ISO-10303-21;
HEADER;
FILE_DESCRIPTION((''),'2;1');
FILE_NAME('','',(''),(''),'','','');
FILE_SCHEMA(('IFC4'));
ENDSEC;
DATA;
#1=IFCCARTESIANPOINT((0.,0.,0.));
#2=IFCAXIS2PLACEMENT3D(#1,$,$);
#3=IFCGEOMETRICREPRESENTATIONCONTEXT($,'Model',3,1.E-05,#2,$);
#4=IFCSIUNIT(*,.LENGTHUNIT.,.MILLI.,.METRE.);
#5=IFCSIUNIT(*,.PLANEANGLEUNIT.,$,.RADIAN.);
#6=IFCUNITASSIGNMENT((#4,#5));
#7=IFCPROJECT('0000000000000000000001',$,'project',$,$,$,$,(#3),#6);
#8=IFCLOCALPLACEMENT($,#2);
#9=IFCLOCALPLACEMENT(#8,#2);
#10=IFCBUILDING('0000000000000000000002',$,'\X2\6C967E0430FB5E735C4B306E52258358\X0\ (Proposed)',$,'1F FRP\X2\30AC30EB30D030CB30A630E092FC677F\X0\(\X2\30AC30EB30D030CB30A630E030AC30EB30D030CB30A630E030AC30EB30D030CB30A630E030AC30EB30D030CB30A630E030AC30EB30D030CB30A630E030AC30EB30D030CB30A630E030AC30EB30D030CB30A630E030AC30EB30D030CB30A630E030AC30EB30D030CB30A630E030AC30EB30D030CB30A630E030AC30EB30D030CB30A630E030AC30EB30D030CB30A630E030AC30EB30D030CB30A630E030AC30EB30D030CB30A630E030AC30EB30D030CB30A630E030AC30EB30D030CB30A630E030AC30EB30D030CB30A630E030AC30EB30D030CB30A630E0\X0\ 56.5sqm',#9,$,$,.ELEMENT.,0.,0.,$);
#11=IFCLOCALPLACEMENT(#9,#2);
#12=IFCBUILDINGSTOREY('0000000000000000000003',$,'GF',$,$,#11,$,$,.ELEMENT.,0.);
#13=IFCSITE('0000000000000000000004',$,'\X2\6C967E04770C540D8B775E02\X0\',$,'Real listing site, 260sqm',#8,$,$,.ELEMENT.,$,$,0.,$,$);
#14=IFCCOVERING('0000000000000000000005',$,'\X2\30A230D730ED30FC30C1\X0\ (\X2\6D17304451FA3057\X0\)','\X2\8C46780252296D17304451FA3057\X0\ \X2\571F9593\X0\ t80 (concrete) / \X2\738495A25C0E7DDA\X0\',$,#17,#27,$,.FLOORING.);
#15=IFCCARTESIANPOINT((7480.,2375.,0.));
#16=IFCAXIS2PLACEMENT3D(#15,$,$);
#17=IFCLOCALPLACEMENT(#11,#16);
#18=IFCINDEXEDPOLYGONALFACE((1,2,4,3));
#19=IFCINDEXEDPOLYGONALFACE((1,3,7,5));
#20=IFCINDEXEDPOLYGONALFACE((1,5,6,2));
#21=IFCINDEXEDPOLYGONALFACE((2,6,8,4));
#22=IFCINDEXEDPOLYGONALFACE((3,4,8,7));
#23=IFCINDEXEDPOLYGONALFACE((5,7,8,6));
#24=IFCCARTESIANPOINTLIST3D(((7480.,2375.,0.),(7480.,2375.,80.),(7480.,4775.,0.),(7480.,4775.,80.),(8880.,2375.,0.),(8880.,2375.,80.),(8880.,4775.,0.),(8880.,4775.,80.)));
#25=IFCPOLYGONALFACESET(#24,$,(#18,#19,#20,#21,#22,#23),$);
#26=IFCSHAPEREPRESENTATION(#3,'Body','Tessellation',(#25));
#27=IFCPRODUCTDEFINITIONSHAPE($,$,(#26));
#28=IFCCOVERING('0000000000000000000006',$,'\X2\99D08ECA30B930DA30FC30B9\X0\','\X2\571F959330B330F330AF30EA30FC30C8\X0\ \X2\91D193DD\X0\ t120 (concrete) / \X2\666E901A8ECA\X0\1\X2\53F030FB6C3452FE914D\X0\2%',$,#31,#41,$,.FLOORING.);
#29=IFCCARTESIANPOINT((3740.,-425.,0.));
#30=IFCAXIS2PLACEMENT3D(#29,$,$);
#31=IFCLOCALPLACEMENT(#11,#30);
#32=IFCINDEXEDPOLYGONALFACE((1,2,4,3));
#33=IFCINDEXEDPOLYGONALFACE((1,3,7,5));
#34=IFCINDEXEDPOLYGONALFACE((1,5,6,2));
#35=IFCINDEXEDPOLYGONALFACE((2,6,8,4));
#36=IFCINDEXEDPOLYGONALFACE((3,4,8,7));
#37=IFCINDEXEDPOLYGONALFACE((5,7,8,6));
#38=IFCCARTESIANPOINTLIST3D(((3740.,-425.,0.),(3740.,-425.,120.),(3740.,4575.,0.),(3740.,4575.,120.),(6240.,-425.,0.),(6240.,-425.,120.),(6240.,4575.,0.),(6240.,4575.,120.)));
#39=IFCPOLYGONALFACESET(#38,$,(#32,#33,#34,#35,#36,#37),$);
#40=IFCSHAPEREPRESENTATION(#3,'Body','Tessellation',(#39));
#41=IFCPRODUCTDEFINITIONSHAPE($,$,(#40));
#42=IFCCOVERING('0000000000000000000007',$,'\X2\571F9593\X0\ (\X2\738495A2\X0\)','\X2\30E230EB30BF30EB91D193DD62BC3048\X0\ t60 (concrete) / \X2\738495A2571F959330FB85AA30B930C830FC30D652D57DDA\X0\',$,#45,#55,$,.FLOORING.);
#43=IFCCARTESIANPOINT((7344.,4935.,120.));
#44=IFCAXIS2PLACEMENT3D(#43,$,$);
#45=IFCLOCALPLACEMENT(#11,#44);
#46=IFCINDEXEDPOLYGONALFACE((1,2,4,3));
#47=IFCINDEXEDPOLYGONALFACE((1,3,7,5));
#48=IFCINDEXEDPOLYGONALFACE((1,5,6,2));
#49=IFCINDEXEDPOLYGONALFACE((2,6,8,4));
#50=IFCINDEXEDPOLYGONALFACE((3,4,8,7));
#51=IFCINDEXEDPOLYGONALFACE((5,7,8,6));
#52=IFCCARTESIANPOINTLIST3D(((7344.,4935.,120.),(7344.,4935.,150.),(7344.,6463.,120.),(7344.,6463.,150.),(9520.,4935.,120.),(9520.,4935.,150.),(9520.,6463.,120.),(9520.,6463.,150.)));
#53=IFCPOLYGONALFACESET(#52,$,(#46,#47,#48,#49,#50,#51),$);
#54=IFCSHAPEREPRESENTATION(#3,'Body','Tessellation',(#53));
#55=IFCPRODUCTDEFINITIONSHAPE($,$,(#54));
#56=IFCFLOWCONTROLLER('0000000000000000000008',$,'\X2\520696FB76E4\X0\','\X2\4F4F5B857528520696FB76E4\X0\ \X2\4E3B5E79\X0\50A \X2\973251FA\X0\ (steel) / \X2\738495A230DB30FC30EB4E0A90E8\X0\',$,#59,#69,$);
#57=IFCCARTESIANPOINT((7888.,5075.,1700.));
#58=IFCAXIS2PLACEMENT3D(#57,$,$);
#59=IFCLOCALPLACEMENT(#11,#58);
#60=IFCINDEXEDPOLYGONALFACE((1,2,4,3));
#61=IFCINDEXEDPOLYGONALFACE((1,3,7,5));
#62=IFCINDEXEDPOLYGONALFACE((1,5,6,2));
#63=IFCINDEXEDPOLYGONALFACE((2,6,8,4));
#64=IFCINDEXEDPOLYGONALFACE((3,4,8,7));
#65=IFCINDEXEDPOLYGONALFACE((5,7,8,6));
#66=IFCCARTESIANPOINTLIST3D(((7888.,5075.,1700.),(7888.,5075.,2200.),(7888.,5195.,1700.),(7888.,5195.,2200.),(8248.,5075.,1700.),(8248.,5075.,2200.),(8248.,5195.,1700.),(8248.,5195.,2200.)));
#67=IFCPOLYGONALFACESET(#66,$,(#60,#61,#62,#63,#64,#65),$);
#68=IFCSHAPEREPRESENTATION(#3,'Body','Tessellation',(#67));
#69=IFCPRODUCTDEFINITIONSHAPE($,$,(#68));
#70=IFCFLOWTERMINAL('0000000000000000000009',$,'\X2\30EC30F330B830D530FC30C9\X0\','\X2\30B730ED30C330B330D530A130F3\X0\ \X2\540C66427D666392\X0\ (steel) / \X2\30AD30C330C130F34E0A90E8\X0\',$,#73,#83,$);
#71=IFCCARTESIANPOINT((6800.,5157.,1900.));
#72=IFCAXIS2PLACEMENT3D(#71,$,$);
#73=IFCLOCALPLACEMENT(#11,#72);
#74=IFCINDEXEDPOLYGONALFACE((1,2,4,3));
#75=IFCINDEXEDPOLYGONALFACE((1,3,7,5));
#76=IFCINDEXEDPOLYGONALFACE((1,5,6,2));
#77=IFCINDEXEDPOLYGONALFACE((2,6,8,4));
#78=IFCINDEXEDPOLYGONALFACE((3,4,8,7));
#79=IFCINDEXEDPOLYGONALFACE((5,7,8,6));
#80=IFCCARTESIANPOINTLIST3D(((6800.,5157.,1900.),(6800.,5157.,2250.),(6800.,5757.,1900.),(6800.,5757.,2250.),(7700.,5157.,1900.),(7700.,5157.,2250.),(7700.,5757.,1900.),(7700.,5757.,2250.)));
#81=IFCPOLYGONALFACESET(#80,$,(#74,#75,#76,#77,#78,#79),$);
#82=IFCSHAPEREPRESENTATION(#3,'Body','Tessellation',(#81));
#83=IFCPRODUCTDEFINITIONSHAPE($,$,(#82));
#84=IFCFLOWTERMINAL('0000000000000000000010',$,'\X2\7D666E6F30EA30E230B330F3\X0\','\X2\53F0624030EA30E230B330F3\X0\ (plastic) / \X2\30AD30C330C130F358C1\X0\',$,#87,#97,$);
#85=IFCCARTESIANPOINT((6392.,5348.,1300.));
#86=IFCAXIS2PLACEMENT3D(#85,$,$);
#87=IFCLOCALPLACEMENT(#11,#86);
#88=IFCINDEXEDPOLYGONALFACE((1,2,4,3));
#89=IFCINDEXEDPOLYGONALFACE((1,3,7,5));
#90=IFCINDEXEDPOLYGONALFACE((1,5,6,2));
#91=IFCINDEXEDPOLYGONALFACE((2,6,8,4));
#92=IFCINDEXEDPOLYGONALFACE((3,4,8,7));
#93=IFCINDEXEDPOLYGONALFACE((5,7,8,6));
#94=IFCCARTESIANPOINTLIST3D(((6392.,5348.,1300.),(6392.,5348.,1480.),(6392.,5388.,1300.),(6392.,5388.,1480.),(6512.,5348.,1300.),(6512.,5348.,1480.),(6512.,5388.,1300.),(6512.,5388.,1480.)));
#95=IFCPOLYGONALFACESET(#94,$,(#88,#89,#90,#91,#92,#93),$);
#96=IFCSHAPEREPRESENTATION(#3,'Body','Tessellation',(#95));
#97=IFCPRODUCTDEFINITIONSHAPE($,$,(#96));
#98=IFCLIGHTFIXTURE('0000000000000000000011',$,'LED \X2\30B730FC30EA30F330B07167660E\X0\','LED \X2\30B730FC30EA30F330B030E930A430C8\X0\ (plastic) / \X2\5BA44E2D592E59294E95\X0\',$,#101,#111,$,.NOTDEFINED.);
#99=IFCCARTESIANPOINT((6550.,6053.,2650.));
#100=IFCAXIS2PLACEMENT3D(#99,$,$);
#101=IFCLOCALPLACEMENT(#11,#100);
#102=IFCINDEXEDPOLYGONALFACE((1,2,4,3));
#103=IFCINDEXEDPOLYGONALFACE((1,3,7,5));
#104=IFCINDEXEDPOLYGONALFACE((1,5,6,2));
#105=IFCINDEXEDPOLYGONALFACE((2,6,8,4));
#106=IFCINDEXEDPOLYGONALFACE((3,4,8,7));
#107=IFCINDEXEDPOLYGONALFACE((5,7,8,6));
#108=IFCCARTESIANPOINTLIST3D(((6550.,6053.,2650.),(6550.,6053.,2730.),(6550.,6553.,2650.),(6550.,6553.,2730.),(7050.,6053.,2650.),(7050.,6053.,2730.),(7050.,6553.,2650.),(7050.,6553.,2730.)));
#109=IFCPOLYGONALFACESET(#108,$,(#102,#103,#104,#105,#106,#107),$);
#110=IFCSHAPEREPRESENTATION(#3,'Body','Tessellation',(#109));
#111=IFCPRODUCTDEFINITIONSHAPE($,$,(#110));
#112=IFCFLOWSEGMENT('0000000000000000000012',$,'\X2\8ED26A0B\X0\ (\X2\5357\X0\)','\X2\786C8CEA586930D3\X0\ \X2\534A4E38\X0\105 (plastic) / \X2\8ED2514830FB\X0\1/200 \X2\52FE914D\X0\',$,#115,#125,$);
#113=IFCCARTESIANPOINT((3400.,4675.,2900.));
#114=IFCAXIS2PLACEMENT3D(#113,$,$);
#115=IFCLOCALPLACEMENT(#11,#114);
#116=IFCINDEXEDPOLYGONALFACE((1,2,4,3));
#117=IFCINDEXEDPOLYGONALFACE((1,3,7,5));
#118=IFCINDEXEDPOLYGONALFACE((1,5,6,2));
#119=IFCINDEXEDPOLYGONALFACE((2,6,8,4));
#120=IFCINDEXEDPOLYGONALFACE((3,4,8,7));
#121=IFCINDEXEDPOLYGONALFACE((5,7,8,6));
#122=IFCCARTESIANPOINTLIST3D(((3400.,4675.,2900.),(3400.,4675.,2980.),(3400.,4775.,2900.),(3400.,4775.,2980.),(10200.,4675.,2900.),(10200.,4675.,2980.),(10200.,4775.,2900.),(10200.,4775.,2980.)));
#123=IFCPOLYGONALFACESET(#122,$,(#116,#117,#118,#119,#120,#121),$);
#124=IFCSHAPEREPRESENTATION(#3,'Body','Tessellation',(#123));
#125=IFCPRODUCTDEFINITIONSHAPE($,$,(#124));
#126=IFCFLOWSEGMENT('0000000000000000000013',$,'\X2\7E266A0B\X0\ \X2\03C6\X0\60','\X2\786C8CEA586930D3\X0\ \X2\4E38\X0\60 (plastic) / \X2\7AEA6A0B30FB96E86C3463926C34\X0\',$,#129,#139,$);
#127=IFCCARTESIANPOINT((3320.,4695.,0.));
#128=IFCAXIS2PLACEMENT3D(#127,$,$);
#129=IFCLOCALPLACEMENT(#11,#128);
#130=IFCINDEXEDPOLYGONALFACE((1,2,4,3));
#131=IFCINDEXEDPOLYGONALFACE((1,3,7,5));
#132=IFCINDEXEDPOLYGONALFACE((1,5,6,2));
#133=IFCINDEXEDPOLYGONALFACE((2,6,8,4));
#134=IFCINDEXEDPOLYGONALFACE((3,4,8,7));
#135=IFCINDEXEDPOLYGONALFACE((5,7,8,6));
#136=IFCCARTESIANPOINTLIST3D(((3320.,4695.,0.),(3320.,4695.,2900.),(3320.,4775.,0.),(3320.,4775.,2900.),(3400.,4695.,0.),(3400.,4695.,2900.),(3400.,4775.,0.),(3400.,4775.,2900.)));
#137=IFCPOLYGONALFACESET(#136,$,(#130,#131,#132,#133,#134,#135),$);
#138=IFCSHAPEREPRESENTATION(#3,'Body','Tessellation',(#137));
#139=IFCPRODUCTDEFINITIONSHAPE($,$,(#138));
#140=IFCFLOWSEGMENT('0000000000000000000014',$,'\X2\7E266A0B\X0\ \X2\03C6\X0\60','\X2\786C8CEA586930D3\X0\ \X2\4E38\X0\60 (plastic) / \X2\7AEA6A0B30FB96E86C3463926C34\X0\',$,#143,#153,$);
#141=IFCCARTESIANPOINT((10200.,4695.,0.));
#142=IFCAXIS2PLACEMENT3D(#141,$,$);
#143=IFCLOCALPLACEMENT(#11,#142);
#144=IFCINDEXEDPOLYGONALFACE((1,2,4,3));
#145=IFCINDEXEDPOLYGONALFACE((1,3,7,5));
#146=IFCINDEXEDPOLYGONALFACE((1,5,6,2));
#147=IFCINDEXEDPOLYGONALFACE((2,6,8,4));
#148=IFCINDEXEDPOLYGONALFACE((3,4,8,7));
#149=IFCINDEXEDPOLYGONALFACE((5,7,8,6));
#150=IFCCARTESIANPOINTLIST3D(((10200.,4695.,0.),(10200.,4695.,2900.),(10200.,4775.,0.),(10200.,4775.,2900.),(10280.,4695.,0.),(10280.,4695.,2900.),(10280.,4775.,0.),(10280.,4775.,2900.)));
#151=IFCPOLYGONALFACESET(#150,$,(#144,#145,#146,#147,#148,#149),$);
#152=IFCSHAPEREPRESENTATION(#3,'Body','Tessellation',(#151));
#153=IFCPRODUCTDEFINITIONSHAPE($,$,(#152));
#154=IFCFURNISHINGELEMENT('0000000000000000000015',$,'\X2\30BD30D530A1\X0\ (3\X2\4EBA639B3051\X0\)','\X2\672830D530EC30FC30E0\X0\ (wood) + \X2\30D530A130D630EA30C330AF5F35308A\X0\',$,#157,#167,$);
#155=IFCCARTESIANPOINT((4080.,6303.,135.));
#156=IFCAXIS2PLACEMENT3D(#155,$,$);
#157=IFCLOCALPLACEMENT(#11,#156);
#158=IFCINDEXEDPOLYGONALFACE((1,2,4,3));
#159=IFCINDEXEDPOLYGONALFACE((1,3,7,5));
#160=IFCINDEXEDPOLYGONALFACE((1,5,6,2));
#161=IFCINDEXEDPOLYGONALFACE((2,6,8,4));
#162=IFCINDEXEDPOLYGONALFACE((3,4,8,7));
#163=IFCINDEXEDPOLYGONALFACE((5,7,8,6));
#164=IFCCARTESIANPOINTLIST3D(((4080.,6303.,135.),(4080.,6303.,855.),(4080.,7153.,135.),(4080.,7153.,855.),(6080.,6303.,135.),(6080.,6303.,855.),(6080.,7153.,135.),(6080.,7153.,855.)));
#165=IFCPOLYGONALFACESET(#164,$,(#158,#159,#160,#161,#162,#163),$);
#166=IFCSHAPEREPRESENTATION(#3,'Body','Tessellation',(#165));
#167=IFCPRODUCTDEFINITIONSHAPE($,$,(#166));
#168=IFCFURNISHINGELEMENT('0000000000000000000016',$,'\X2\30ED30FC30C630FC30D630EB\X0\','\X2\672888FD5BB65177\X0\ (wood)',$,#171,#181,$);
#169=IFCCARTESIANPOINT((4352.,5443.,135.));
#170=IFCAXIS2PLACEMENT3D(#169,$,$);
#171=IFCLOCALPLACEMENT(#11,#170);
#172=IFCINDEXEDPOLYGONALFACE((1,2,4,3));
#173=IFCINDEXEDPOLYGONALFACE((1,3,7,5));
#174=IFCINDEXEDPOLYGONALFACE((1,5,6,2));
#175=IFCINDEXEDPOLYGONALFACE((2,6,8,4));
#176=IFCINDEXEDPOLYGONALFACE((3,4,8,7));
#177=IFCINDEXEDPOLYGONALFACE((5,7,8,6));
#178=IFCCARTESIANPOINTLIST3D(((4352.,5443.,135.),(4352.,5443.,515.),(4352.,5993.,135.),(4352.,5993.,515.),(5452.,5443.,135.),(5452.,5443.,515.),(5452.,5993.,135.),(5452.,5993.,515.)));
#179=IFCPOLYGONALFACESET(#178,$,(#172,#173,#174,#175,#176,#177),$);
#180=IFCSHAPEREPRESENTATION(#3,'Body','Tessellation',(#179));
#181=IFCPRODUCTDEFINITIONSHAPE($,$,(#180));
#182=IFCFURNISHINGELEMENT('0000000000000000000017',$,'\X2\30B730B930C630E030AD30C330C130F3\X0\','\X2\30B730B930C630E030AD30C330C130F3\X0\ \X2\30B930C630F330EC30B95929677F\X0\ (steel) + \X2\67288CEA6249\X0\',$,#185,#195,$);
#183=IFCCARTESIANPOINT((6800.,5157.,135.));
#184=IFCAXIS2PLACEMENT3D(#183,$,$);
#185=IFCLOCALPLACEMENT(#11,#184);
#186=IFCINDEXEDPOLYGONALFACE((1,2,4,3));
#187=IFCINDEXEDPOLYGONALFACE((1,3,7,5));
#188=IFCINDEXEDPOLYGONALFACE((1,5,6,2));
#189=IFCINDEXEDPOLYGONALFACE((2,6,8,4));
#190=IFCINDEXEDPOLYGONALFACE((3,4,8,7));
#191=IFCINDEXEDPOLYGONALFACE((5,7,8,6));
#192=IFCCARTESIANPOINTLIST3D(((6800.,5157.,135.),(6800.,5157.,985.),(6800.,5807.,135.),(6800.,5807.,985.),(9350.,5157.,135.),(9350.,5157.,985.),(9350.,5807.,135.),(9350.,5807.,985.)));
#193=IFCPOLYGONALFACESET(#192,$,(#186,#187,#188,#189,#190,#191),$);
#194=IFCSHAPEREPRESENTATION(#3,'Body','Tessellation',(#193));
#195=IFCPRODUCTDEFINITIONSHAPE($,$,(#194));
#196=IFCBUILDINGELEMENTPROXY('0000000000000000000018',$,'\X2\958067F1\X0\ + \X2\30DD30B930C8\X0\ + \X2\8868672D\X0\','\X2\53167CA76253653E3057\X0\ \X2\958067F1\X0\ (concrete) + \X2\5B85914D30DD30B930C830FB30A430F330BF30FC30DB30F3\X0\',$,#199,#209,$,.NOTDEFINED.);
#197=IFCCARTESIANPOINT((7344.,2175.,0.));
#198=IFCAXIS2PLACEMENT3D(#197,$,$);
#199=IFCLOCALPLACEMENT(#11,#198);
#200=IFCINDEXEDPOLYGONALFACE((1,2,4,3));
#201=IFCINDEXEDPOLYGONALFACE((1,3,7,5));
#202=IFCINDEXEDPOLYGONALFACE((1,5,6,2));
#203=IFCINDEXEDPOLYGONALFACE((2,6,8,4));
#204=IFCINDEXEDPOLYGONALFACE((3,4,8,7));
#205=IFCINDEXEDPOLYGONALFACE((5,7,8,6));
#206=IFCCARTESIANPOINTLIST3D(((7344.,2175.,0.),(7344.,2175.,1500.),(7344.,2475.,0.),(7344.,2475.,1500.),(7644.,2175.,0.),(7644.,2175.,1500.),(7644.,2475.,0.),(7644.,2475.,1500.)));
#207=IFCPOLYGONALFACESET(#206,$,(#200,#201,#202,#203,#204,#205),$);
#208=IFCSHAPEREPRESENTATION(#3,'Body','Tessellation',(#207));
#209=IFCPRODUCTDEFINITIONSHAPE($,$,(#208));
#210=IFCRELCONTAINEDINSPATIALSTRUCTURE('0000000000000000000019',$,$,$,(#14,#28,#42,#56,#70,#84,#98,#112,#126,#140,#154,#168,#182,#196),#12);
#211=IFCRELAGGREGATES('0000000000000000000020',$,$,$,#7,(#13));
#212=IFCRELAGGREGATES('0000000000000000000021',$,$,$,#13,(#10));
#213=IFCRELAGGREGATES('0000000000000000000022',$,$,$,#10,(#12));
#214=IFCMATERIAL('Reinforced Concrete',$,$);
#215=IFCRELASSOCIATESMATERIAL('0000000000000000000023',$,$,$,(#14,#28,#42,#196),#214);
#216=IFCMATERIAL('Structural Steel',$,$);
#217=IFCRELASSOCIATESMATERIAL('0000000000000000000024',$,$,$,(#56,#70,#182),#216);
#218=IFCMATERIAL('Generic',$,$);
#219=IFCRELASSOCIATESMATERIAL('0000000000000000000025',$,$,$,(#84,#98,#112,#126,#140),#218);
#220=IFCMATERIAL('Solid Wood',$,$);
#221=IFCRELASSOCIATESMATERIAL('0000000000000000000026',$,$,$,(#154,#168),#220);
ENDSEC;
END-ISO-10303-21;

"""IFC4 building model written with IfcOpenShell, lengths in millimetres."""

from ifc_helpers import new_model, si_unit, frame, frame_2d, origin, place, context, project, spatial, rectangle, extrude, material, element, save


model = new_model("IFC4")

# Units and contexts
model_context = context("Model", 3, precision=1e-05, world=origin())
ifc_project = project(units=[si_unit("LENGTHUNIT", "METRE", prefix="MILLI"), si_unit("PLANEANGLEUNIT", "RADIAN")], contexts=[model_context])

# Site, building, storey
site_placement = place(None, origin())
site = spatial("IfcSite", under=ifc_project, at=site_placement, Name="沖縄県名護市", ObjectType="Real listing site, 260sqm", CompositionType="ELEMENT", RefElevation=0.0)
building_placement = place(site_placement, origin())
building = spatial("IfcBuilding", under=site, at=building_placement, Name="沖縄・平屋の別荘 (Proposed)", ObjectType="1F FRPガルバニウム鋼板(ガルバニウムガルバニウムガルバニウムガルバニウムガルバニウムガルバニウムガルバニウムガルバニウムガルバニウムガルバニウムガルバニウムガルバニウムガルバニウムガルバニウムガルバニウムガルバニウムガルバニウムガルバニウム 56.5sqm", CompositionType="ELEMENT", ElevationOfRefHeight=0.0, ElevationOfTerrain=0.0)
storey_placement = place(building_placement, origin())
storey = spatial("IfcBuildingStorey", under=building, at=storey_placement, Name="GF", CompositionType="ELEMENT", Elevation=0.0)

# Shared definitions
ifc_material_1 = material(Name="Solid Wood")

# Shared definitions
ifc_material_2 = material(Name="Reinforced Concrete")

# Shared definitions
ifc_material_3 = material(Name="Structural Steel")

# Coverings
ifc_material_4 = material(Name="Generic")
covering_1_placement = place(storey_placement, frame((7480.0, 2375.0, 0.0)))
element("IfcCovering", 1, at=covering_1_placement, inside=storey, material=ifc_material_2, Name="アプローチ (洗い出し)", Description="豆砂利洗い出し 土間 t80 (concrete) / 玄関導線", PredefinedType="FLOORING", context=model_context, shape_type="SweptSolid", body=[
    extrude(rectangle(XDim=1400.0, YDim=2400.0, at=frame_2d((700.0, 1200.0))), frame((7480.0, 2375.0, 0.0)), (0.0, 0.0, 1.0), 80.0),
])
covering_2_placement = place(storey_placement, frame((3740.0, -425.0, 0.0)))
element("IfcCovering", 2, at=covering_2_placement, inside=storey, material=ifc_material_2, Name="駐車スペース", Description="土間コンクリート 金鏝 t120 (concrete) / 普通車1台・水勾配2%", PredefinedType="FLOORING", context=model_context, shape_type="SweptSolid", body=[
    extrude(rectangle(XDim=2500.0, YDim=5000.0, at=frame_2d((1250.0, 2500.0))), frame((3740.0, -425.0, 0.0)), (0.0, 0.0, 1.0), 120.0),
])
covering_3_placement = place(storey_placement, frame((7344.0, 4935.0, 120.0)))
element("IfcCovering", 3, at=covering_3_placement, inside=storey, material=ifc_material_2, Name="土間 (玄関)", Description="モルタル金鏝押え t60 (concrete) / 玄関土間・薪ストーブ動線", PredefinedType="FLOORING", context=model_context, shape_type="SweptSolid", body=[
    extrude(rectangle(XDim=2176.0, YDim=1528.0, at=frame_2d((1088.0, 764.0))), frame((7344.0, 4935.0, 120.0)), (0.0, 0.0, 1.0), 30.0),
])

# Flow controller
flow_controller_placement = place(storey_placement, frame((7888.0, 5075.0, 1700.0)))
element("IfcFlowController", 4, at=flow_controller_placement, inside=storey, material=ifc_material_3, Name="分電盤", Description="住宅用分電盤 主幹50A 露出 (steel) / 玄関ホール上部", context=model_context, shape_type="SweptSolid", body=[
    extrude(rectangle(XDim=360.0, YDim=120.0, at=frame_2d((180.0, 60.0))), frame((7888.0, 5075.0, 1700.0)), (0.0, 0.0, 1.0), 500.0),
])

# Flow terminals
flow_terminal_1_placement = place(storey_placement, frame((6800.0, 5157.0, 1900.0)))
element("IfcFlowTerminal", 5, at=flow_terminal_1_placement, inside=storey, material=ifc_material_3, Name="レンジフード", Description="シロッコファン 同時給排 (steel) / キッチン上部", context=model_context, shape_type="SweptSolid", body=[
    extrude(rectangle(XDim=900.0, YDim=600.0, at=frame_2d((450.0, 300.0))), frame((6800.0, 5157.0, 1900.0)), (0.0, 0.0, 1.0), 350.0),
])
flow_terminal_2_placement = place(storey_placement, frame((6392.0, 5348.0, 1300.0)))
element("IfcFlowTerminal", 6, at=flow_terminal_2_placement, inside=storey, material=ifc_material_4, Name="給湯リモコン", Description="台所リモコン (plastic) / キッチン壁", context=model_context, shape_type="SweptSolid", body=[
    extrude(rectangle(XDim=120.0, YDim=40.0, at=frame_2d((60.0, 20.0))), frame((6392.0, 5348.0, 1300.0)), (0.0, 0.0, 1.0), 180.0),
])

# Light fixture
light_fixture_placement = place(storey_placement, frame((6550.0, 6053.0, 2650.0)))
element("IfcLightFixture", 7, at=light_fixture_placement, inside=storey, material=ifc_material_4, Name="LED シーリング照明", Description="LED シーリングライト (plastic) / 室中央天井", PredefinedType="NOTDEFINED", context=model_context, shape_type="SweptSolid", body=[
    extrude(rectangle(XDim=500.0, YDim=500.0, at=frame_2d((250.0, 250.0))), frame((6550.0, 6053.0, 2650.0)), (0.0, 0.0, 1.0), 80.0),
])

# Flow segments
flow_segment_1_placement = place(storey_placement, frame((3400.0, 4675.0, 2900.0)))
element("IfcFlowSegment", 8, at=flow_segment_1_placement, inside=storey, material=ifc_material_4, Name="軒樋 (南)", Description="硬質塩ビ 半丸105 (plastic) / 軒先・1/200 勾配", context=model_context, shape_type="SweptSolid", body=[
    extrude(rectangle(XDim=6800.0, YDim=100.0, at=frame_2d((3400.0, 50.0))), frame((3400.0, 4675.0, 2900.0)), (0.0, 0.0, 1.0), 80.0),
])
flow_segment_2_placement = place(storey_placement, frame((3320.0, 4695.0, 0.0)))
element("IfcFlowSegment", 9, at=flow_segment_2_placement, inside=storey, material=ifc_material_4, Name="縦樋 φ60", Description="硬質塩ビ 丸60 (plastic) / 竪樋・雨水排水", context=model_context, shape_type="SweptSolid", body=[
    extrude(rectangle(XDim=80.0, YDim=80.0, at=frame_2d((40.0, 40.0))), frame((3320.0, 4695.0, 0.0)), (0.0, 0.0, 1.0), 2900.0),
])
flow_segment_3_placement = place(storey_placement, frame((10200.0, 4695.0, 0.0)))
element("IfcFlowSegment", 10, at=flow_segment_3_placement, inside=storey, material=ifc_material_4, Name="縦樋 φ60", Description="硬質塩ビ 丸60 (plastic) / 竪樋・雨水排水", context=model_context, shape_type="SweptSolid", body=[
    extrude(rectangle(XDim=80.0, YDim=80.0, at=frame_2d((40.0, 40.0))), frame((10200.0, 4695.0, 0.0)), (0.0, 0.0, 1.0), 2900.0),
])

# Furnishing elements
furnishing_1_placement = place(storey_placement, frame((4080.0, 6303.0, 135.0)))
element("IfcFurnishingElement", 11, at=furnishing_1_placement, inside=storey, material=ifc_material_1, Name="ソファ (3人掛け)", Description="木フレーム (wood) + ファブリック張り", context=model_context, shape_type="SweptSolid", body=[
    extrude(rectangle(XDim=2000.0, YDim=850.0, at=frame_2d((1000.0, 425.0))), frame((4080.0, 6303.0, 135.0)), (0.0, 0.0, 1.0), 720.0),
])
furnishing_2_placement = place(storey_placement, frame((4352.0, 5443.0, 135.0)))
element("IfcFurnishingElement", 12, at=furnishing_2_placement, inside=storey, material=ifc_material_1, Name="ローテーブル", Description="木製家具 (wood)", context=model_context, shape_type="SweptSolid", body=[
    extrude(rectangle(XDim=1100.0, YDim=550.0, at=frame_2d((550.0, 275.0))), frame((4352.0, 5443.0, 135.0)), (0.0, 0.0, 1.0), 380.0),
])
furnishing_3_placement = place(storey_placement, frame((6800.0, 5157.0, 135.0)))
element("IfcFurnishingElement", 13, at=furnishing_3_placement, inside=storey, material=ifc_material_3, Name="システムキッチン", Description="システムキッチン ステンレス天板 (steel) + 木質扉", context=model_context, shape_type="SweptSolid", body=[
    extrude(rectangle(XDim=2550.0, YDim=650.0, at=frame_2d((1275.0, 325.0))), frame((6800.0, 5157.0, 135.0)), (0.0, 0.0, 1.0), 850.0),
])

# Building element proxy
proxy_placement = place(storey_placement, frame((7344.0, 2175.0, 0.0)))
element("IfcBuildingElementProxy", 14, at=proxy_placement, inside=storey, material=ifc_material_2, Name="門柱 + ポスト + 表札", Description="化粧打放し 門柱 (concrete) + 宅配ポスト・インターホン", PredefinedType="NOTDEFINED", context=model_context, shape_type="SweptSolid", body=[
    extrude(rectangle(XDim=300.0, YDim=300.0, at=frame_2d((150.0, 150.0))), frame((7344.0, 2175.0, 0.0)), (0.0, 0.0, 1.0), 1500.0),
])

save(model, "model.ifc")
